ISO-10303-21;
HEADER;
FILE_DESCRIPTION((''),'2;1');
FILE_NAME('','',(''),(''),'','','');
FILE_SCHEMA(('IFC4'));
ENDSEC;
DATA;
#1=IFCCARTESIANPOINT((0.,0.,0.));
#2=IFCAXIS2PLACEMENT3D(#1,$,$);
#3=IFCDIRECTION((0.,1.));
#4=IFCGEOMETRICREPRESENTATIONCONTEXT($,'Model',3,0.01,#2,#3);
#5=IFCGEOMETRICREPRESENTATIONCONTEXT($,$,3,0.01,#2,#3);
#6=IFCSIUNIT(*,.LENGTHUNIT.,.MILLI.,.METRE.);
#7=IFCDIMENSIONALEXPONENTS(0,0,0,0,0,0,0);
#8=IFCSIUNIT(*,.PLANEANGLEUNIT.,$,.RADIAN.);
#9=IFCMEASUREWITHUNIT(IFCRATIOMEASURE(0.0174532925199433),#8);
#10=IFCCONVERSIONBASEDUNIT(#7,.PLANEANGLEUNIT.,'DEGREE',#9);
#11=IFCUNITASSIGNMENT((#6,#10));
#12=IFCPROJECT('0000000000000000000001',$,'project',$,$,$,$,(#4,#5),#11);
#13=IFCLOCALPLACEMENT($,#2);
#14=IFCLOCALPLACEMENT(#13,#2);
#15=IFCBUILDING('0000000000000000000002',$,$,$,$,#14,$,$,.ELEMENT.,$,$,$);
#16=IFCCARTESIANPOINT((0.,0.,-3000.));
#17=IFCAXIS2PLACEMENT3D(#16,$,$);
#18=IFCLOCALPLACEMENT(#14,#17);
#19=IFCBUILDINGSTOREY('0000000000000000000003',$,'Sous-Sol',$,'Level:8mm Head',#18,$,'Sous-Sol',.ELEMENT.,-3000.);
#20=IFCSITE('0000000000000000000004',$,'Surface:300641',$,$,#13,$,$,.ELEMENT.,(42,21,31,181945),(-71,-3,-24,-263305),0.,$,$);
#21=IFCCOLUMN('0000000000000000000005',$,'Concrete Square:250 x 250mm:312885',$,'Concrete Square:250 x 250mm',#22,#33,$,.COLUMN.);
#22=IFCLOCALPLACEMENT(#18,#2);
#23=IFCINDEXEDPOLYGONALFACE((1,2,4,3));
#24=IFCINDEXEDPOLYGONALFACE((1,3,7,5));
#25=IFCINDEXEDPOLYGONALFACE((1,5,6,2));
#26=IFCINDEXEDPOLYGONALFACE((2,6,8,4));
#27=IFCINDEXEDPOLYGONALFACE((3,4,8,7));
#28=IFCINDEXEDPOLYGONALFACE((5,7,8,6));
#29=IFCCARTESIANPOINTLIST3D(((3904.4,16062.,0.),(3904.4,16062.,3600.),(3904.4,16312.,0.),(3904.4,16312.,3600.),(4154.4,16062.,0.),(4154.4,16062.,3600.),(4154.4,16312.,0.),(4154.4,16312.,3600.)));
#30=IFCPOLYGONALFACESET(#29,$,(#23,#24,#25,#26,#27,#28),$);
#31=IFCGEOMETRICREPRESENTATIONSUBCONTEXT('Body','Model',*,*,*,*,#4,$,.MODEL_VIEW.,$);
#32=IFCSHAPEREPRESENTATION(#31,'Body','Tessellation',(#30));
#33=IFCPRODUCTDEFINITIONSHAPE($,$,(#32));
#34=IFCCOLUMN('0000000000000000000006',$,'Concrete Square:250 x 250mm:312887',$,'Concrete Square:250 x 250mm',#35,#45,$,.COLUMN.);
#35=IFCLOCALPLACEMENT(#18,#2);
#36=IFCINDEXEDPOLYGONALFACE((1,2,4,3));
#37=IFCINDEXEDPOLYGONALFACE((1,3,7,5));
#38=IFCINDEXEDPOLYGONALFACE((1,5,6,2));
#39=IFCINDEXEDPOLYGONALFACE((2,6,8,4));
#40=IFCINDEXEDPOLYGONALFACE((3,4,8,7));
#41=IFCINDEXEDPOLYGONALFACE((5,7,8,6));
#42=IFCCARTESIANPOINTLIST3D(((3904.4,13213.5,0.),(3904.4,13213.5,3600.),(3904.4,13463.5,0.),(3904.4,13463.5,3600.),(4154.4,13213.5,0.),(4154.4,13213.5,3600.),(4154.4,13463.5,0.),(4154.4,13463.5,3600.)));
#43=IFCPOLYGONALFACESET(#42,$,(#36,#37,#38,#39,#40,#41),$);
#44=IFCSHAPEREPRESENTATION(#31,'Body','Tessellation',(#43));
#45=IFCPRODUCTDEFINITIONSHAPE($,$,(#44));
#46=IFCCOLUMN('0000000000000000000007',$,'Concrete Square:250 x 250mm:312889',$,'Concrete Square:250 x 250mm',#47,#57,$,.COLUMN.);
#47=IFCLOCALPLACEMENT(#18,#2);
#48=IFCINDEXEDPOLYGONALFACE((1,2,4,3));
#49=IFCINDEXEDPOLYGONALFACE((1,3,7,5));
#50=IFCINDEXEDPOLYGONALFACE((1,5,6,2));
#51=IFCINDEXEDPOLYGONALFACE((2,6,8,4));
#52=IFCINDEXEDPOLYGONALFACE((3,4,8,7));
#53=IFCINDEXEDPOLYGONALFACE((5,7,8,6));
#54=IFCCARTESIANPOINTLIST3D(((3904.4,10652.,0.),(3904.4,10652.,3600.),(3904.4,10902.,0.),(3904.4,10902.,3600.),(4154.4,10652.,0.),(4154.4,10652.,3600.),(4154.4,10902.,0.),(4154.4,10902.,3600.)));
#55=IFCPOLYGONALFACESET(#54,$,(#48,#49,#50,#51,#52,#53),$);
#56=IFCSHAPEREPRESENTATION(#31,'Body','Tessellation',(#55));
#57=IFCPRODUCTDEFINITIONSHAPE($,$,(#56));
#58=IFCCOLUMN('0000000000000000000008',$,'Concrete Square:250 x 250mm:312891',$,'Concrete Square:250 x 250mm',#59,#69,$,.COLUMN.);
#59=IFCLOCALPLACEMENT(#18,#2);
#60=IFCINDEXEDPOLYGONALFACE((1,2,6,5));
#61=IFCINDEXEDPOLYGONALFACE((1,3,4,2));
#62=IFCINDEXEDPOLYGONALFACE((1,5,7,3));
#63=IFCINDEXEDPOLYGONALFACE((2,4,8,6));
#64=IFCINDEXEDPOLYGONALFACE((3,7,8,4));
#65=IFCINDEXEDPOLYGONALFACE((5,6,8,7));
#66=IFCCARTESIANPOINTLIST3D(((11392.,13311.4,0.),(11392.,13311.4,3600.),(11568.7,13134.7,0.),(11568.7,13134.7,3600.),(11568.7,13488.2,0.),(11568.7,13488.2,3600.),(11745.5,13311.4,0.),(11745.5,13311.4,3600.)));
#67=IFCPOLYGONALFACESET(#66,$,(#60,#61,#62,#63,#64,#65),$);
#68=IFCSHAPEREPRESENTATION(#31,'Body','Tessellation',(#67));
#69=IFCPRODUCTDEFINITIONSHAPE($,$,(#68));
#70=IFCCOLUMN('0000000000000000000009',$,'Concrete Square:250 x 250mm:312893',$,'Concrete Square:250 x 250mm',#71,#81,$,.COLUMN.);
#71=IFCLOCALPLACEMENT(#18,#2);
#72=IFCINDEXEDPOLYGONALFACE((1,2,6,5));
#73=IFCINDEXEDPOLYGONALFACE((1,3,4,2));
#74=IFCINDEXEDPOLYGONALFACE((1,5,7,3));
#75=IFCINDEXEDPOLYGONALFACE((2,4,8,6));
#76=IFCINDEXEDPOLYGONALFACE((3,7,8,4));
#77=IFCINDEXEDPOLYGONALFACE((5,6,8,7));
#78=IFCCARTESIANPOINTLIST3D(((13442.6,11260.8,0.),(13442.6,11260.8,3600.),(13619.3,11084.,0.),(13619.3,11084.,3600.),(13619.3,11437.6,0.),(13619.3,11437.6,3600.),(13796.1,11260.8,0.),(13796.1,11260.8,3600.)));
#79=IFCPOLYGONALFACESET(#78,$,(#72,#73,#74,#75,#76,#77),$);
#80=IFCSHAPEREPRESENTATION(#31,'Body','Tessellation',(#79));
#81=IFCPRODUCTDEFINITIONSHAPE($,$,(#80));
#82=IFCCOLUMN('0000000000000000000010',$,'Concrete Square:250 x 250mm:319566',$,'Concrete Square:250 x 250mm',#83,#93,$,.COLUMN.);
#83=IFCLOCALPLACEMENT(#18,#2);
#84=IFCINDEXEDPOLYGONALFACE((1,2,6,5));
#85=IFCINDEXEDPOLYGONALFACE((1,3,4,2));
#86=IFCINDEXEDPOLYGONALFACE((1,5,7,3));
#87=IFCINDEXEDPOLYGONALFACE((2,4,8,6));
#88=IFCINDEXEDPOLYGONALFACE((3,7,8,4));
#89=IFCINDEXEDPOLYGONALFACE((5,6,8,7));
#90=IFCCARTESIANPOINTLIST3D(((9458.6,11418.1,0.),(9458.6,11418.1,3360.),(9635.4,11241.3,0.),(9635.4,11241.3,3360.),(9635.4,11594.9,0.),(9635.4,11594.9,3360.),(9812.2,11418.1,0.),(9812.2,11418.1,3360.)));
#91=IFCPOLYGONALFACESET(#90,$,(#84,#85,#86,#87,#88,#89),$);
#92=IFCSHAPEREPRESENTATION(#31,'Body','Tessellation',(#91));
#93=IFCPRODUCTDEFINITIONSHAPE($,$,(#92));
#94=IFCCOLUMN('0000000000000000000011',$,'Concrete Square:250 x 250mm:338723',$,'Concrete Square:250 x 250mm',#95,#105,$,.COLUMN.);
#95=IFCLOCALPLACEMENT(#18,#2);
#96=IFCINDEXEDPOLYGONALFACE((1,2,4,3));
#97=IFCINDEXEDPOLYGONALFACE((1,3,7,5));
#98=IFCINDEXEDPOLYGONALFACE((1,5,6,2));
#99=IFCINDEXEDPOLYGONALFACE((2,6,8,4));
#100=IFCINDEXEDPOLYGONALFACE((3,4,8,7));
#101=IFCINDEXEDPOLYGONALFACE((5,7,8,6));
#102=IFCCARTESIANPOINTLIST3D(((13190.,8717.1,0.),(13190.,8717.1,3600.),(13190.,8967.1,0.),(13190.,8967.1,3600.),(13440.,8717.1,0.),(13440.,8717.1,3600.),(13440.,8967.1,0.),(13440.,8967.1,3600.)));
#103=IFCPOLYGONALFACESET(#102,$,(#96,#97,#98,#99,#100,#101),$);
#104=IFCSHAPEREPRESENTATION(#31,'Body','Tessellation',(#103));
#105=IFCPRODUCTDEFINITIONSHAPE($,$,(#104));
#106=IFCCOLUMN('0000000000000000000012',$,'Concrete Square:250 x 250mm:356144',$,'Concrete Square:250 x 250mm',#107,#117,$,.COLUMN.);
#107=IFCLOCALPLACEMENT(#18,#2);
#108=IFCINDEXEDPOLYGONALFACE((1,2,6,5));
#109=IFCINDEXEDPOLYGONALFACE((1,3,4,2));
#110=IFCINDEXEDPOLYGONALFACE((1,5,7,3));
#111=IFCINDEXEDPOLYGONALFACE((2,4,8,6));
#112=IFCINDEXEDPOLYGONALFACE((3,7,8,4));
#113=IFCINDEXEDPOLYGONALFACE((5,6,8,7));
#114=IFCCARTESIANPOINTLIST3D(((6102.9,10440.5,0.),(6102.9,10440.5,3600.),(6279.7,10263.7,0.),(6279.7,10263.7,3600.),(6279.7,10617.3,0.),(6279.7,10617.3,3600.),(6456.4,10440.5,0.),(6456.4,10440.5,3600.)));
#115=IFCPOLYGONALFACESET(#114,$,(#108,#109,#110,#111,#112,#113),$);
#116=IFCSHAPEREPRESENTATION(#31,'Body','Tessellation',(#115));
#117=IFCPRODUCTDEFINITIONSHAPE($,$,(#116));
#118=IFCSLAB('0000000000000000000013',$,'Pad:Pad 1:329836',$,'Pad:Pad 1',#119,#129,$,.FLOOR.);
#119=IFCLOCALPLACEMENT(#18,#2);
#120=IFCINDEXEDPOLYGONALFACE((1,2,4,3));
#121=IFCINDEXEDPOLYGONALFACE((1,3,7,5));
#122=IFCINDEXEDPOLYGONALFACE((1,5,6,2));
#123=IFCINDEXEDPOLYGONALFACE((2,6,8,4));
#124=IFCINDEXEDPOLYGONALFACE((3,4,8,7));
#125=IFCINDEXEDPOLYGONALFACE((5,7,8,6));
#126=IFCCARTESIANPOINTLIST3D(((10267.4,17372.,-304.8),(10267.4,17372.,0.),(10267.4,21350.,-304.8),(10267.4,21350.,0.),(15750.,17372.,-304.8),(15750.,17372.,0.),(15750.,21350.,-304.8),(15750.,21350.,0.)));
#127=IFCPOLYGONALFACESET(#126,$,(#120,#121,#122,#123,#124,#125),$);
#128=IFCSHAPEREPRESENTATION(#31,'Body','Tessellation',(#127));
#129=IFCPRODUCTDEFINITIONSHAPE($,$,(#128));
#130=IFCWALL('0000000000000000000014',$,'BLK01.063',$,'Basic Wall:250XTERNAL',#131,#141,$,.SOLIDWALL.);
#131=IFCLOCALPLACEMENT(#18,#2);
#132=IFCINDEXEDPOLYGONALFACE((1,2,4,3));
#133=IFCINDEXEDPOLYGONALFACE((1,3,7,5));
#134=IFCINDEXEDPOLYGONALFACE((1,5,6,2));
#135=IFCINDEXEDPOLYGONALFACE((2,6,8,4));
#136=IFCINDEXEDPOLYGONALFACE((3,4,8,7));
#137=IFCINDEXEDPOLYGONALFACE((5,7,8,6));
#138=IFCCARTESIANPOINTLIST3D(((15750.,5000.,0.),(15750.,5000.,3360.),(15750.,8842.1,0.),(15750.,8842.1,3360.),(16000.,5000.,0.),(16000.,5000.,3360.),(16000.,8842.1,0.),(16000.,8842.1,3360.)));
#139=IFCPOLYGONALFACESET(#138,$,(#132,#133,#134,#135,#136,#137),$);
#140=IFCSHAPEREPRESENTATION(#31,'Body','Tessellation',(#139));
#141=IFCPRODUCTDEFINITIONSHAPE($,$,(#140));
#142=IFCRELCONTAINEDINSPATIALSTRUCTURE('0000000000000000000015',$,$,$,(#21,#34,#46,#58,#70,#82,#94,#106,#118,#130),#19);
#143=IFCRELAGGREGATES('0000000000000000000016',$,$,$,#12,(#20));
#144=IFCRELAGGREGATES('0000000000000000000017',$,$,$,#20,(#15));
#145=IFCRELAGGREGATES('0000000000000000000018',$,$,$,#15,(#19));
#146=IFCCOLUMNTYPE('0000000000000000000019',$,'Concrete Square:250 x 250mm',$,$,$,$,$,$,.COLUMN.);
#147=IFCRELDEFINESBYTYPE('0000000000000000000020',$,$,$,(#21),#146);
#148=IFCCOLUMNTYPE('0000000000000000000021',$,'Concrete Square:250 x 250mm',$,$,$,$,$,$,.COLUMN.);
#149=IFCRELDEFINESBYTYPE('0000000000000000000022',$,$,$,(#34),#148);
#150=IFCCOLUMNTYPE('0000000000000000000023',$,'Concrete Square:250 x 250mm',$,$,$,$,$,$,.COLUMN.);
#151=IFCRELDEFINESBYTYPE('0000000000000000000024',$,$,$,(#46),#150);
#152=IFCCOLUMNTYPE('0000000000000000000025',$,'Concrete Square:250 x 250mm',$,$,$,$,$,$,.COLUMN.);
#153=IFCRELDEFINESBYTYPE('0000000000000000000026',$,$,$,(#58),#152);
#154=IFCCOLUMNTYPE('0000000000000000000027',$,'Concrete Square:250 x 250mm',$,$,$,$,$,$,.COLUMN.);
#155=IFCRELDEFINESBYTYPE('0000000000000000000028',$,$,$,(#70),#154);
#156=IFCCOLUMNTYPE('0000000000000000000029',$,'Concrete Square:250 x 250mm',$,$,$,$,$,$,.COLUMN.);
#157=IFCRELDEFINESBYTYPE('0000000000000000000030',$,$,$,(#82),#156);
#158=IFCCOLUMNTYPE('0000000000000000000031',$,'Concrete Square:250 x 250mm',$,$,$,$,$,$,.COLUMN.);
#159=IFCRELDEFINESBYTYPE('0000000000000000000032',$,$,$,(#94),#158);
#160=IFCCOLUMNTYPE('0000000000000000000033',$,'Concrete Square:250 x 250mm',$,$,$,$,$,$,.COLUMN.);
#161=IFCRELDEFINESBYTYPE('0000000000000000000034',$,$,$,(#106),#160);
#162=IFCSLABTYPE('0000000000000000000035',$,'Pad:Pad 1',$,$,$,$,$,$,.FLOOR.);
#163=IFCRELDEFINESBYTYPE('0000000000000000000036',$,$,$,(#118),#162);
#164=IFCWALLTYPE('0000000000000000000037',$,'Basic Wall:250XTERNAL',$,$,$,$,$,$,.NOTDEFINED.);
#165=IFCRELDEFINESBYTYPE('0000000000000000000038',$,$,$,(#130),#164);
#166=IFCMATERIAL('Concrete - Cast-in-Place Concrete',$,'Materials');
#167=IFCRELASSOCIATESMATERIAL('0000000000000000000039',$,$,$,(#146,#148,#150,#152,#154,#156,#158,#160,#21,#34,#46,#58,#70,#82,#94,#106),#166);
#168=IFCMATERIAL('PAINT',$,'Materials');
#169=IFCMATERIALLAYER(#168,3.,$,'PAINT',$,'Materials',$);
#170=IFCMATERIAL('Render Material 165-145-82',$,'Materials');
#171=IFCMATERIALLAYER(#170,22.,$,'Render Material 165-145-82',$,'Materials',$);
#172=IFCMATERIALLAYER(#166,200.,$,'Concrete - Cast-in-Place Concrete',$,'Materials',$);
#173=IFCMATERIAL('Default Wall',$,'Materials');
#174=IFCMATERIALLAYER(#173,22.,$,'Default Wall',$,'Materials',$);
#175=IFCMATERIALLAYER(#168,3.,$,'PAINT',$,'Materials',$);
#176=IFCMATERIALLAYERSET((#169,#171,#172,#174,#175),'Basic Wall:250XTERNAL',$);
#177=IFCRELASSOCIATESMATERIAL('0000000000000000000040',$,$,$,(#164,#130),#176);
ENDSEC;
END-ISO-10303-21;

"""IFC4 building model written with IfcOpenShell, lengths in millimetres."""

from ifc_helpers import new_model, entity, si_unit, converted_unit, direction, frame, frame_2d, origin, origin_2d_with_axis, place, context, subcontext, project, spatial, polyline, rectangle, extrude, clip, halfspace, bounded_halfspace, source, transform, mapped, material, layer, layer_set, layer_usage, material_profile, profile_set, profile_usage, type_object, type_shapes, element, save


model = new_model("IFC4")

# Units and contexts
model_context = context("Model", 3, precision=0.01, world=origin(), true_north=direction((0.0, 1.0)))
context_of_model = context(None, 3, precision=0.01, world=origin(), true_north=direction((0.0, 1.0)))
body_context = subcontext(model_context, "Body", "Model", "MODEL_VIEW")
ifc_project = project(units=[si_unit("LENGTHUNIT", "METRE", prefix="MILLI"), converted_unit("PLANEANGLEUNIT", "DEGREE", entity("IfcRatioMeasure", 0.0174532925199433), si_unit("PLANEANGLEUNIT", "RADIAN"), dimensions=[0, 0, 0, 0, 0, 0, 0])], contexts=[model_context, context_of_model])

# Site, building, storey
site_placement = place(None, origin())
site = spatial("IfcSite", under=ifc_project, at=site_placement, Name="Surface:300641", CompositionType="ELEMENT", RefLatitude=(42, 21, 31, 181945), RefLongitude=(-71, -3, -24, -263305), RefElevation=0.0)
building_placement = place(site_placement, origin())
building = spatial("IfcBuilding", under=site, at=building_placement, CompositionType="ELEMENT")
storey_placement = place(building_placement, frame((0.0, 0.0, -3000.0)))
storey = spatial("IfcBuildingStorey", under=building, at=storey_placement, Name="Sous-Sol", ObjectType="Level:8mm Head", LongName="Sous-Sol", CompositionType="ELEMENT", Elevation=-3000.0)

# Columns
ifc_material_1 = material(Name="Concrete - Cast-in-Place Concrete", Category="Materials")
ifc_material_profile = material_profile(ifc_material_1, rectangle(XDim=250.0, YDim=250.0, at=frame_2d((0.0, 0.0), x_axis=(1.0, 0.0))), Name="250 x 250mm")
ifc_profile_set = profile_set([ifc_material_profile], Name="250 x 250mm")
ifc_profile_usage_1 = profile_usage(ifc_profile_set)
column_type_1 = type_object("IfcColumnType", Name="Concrete Square:250 x 250mm", PredefinedType="COLUMN", material=ifc_profile_set)
shared_shape_1 = source(origin(), body_context, "Body", "SweptSolid", [
    extrude(rectangle(XDim=250.0, YDim=250.0, at=frame_2d((0.0, 0.0), x_axis=(1.0, 0.0))), frame((4029.4, 16187.0, -3000.0), z_axis=(0.0, 0.0, 1.0), x_axis=(0.0, -1.0, 0.0)), (0.0, 0.0, 1.0), 3600.0),
])
type_shapes(column_type_1, [shared_shape_1])
column_1_placement = place(storey_placement, frame((0.0, 0.0, 3000.0)))
element("IfcColumn", 1, at=column_1_placement, inside=storey, type_object=column_type_1, material=ifc_profile_usage_1, Name="Concrete Square:250 x 250mm:312885", ObjectType="Concrete Square:250 x 250mm", PredefinedType="COLUMN", context=body_context, shape_type="MappedRepresentation", body=[
    mapped(shared_shape_1, transform((0.0, 0.0, 0.0), scale=1.0)),
])
ifc_profile_usage_2 = profile_usage(ifc_profile_set)
column_type_2 = type_object("IfcColumnType", Name="Concrete Square:250 x 250mm", PredefinedType="COLUMN", material=ifc_profile_set)
shared_shape_2 = source(origin(), body_context, "Body", "SweptSolid", [
    extrude(rectangle(XDim=250.0, YDim=250.0, at=frame_2d((0.0, 0.0), x_axis=(1.0, 0.0))), frame((4029.4, 13338.5, -3000.0), z_axis=(0.0, 0.0, 1.0), x_axis=(0.0, -1.0, 0.0)), (0.0, 0.0, 1.0), 3600.0),
])
type_shapes(column_type_2, [shared_shape_2])
column_2_placement = place(storey_placement, frame((0.0, 0.0, 3000.0)))
element("IfcColumn", 2, at=column_2_placement, inside=storey, type_object=column_type_2, material=ifc_profile_usage_2, Name="Concrete Square:250 x 250mm:312887", ObjectType="Concrete Square:250 x 250mm", PredefinedType="COLUMN", context=body_context, shape_type="MappedRepresentation", body=[
    mapped(shared_shape_2, transform((0.0, 0.0, 0.0), scale=1.0)),
])
ifc_profile_usage_3 = profile_usage(ifc_profile_set)
column_type_3 = type_object("IfcColumnType", Name="Concrete Square:250 x 250mm", PredefinedType="COLUMN", material=ifc_profile_set)
shared_shape_3 = source(origin(), body_context, "Body", "SweptSolid", [
    extrude(rectangle(XDim=250.0, YDim=250.0, at=frame_2d((0.0, 0.0), x_axis=(1.0, 0.0))), frame((4029.4, 10777.0, -3000.0), z_axis=(0.0, 0.0, 1.0), x_axis=(0.0, -1.0, 0.0)), (0.0, 0.0, 1.0), 3600.0),
])
type_shapes(column_type_3, [shared_shape_3])
column_3_placement = place(storey_placement, frame((0.0, 0.0, 3000.0)))
element("IfcColumn", 3, at=column_3_placement, inside=storey, type_object=column_type_3, material=ifc_profile_usage_3, Name="Concrete Square:250 x 250mm:312889", ObjectType="Concrete Square:250 x 250mm", PredefinedType="COLUMN", context=body_context, shape_type="MappedRepresentation", body=[
    mapped(shared_shape_3, transform((0.0, 0.0, 0.0), scale=1.0)),
])
ifc_profile_usage_4 = profile_usage(ifc_profile_set)
column_type_4 = type_object("IfcColumnType", Name="Concrete Square:250 x 250mm", PredefinedType="COLUMN", material=ifc_profile_set)
shared_shape_4 = source(origin(), body_context, "Body", "SweptSolid", [
    extrude(rectangle(XDim=250.0, YDim=250.0, at=origin_2d_with_axis()), frame((11568.7, 13311.4, -3000.0), z_axis=(0.0, 0.0, 1.0), x_axis=(-0.707107, 0.707107, 0.0)), (0.0, 0.0, 1.0), 3600.0),
])
type_shapes(column_type_4, [shared_shape_4])
column_4_placement = place(storey_placement, frame((0.0, 0.0, 3000.0)))
element("IfcColumn", 4, at=column_4_placement, inside=storey, type_object=column_type_4, material=ifc_profile_usage_4, Name="Concrete Square:250 x 250mm:312891", ObjectType="Concrete Square:250 x 250mm", PredefinedType="COLUMN", context=body_context, shape_type="MappedRepresentation", body=[
    mapped(shared_shape_4, transform((0.0, 0.0, 0.0), scale=1.0)),
])
ifc_profile_usage_5 = profile_usage(ifc_profile_set)
column_type_5 = type_object("IfcColumnType", Name="Concrete Square:250 x 250mm", PredefinedType="COLUMN", material=ifc_profile_set)
shared_shape_5 = source(origin(), body_context, "Body", "SweptSolid", [
    extrude(rectangle(XDim=250.0, YDim=250.0, at=frame_2d((0.0, 0.0), x_axis=(1.0, 0.0))), frame((13619.3, 11260.8, -3000.0), z_axis=(0.0, 0.0, 1.0), x_axis=(-0.707107, 0.707107, 0.0)), (0.0, 0.0, 1.0), 3600.0),
])
type_shapes(column_type_5, [shared_shape_5])
column_5_placement = place(storey_placement, frame((0.0, 0.0, 3000.0)))
element("IfcColumn", 5, at=column_5_placement, inside=storey, type_object=column_type_5, material=ifc_profile_usage_5, Name="Concrete Square:250 x 250mm:312893", ObjectType="Concrete Square:250 x 250mm", PredefinedType="COLUMN", context=body_context, shape_type="MappedRepresentation", body=[
    mapped(shared_shape_5, transform((0.0, 0.0, 0.0), scale=1.0)),
])
ifc_profile_usage_6 = profile_usage(ifc_profile_set)
column_type_6 = type_object("IfcColumnType", Name="Concrete Square:250 x 250mm", PredefinedType="COLUMN", material=ifc_profile_set)
shared_shape_6 = source(origin(), body_context, "Body", "SweptSolid", [
    extrude(rectangle(XDim=250.0, YDim=250.0, at=frame_2d((0.0, 0.0), x_axis=(1.0, 0.0))), frame((9635.4, 11418.1, -3000.0), z_axis=(0.0, 0.0, 1.0), x_axis=(-0.707107, 0.707107, 0.0)), (0.0, 0.0, 1.0), 3360.0),
])
type_shapes(column_type_6, [shared_shape_6])
column_6_placement = place(storey_placement, frame((0.0, 0.0, 3000.0)))
element("IfcColumn", 6, at=column_6_placement, inside=storey, type_object=column_type_6, material=ifc_profile_usage_6, Name="Concrete Square:250 x 250mm:319566", ObjectType="Concrete Square:250 x 250mm", PredefinedType="COLUMN", context=body_context, shape_type="MappedRepresentation", body=[
    mapped(shared_shape_6, transform((0.0, 0.0, 0.0), scale=1.0)),
])
ifc_profile_usage_7 = profile_usage(ifc_profile_set)
column_type_7 = type_object("IfcColumnType", Name="Concrete Square:250 x 250mm", PredefinedType="COLUMN", material=ifc_profile_set)
shared_shape_7 = source(origin(), body_context, "Body", "SweptSolid", [
    extrude(rectangle(XDim=250.0, YDim=250.0, at=frame_2d((0.0, 0.0), x_axis=(1.0, 0.0))), frame((13315.0, 8842.1, -3000.0), z_axis=(0.0, 0.0, 1.0), x_axis=(0.0, -1.0, 0.0)), (0.0, 0.0, 1.0), 3600.0),
])
type_shapes(column_type_7, [shared_shape_7])
column_7_placement = place(storey_placement, frame((0.0, 0.0, 3000.0)))
element("IfcColumn", 7, at=column_7_placement, inside=storey, type_object=column_type_7, material=ifc_profile_usage_7, Name="Concrete Square:250 x 250mm:338723", ObjectType="Concrete Square:250 x 250mm", PredefinedType="COLUMN", context=body_context, shape_type="MappedRepresentation", body=[
    mapped(shared_shape_7, transform((0.0, 0.0, 0.0), scale=1.0)),
])
ifc_profile_usage_8 = profile_usage(ifc_profile_set)
column_type_8 = type_object("IfcColumnType", Name="Concrete Square:250 x 250mm", PredefinedType="COLUMN", material=ifc_profile_set)
shared_shape_8 = source(origin(), body_context, "Body", "SweptSolid", [
    extrude(rectangle(XDim=250.0, YDim=250.0, at=origin_2d_with_axis()), frame((6279.7, 10440.5, -3000.0), z_axis=(0.0, 0.0, 1.0), x_axis=(-0.707107, 0.707107, 0.0)), (0.0, 0.0, 1.0), 3600.0),
])
type_shapes(column_type_8, [shared_shape_8])
column_8_placement = place(storey_placement, frame((0.0, 0.0, 3000.0)))
element("IfcColumn", 8, at=column_8_placement, inside=storey, type_object=column_type_8, material=ifc_profile_usage_8, Name="Concrete Square:250 x 250mm:356144", ObjectType="Concrete Square:250 x 250mm", PredefinedType="COLUMN", context=body_context, shape_type="MappedRepresentation", body=[
    mapped(shared_shape_8, transform((0.0, 0.0, 0.0), scale=1.0)),
])

# Slab
slab_type_1 = type_object("IfcSlabType", Name="Pad:Pad 1", PredefinedType="FLOOR")
slab_1_placement = place(storey_placement, origin())
element("IfcSlab", 9, at=slab_1_placement, inside=storey, type_object=slab_type_1, Name="Pad:Pad 1:329836", ObjectType="Pad:Pad 1", PredefinedType="FLOOR", context=body_context, shape_type="SweptSolid", body=[
    extrude(rectangle(XDim=5482.6, YDim=3978.0, at=frame_2d((0.0, 0.0), x_axis=(1.0, 0.0))), frame((13008.7, 19361.0, -304.8)), (0.0, 0.0, 1.0), 304.8),
])

# Wall
ifc_material_2 = material(Name="PAINT", Category="Materials")
ifc_layer_1 = layer(ifc_material_2, 3.0, Name="PAINT", Category="Materials")
ifc_material_3 = material(Name="Render Material 165-145-82", Category="Materials")
ifc_layer_2 = layer(ifc_material_3, 22.0, Name="Render Material 165-145-82", Category="Materials")
ifc_layer_3 = layer(ifc_material_1, 200.0, Name="Concrete - Cast-in-Place Concrete", Category="Materials")
ifc_material_4 = material(Name="Default Wall", Category="Materials")
ifc_layer_4 = layer(ifc_material_4, 22.0, Name="Default Wall", Category="Materials")
ifc_layer_5 = layer(ifc_material_2, 3.0, Name="PAINT", Category="Materials")
ifc_layer_set = layer_set([ifc_layer_1, ifc_layer_2, ifc_layer_3, ifc_layer_4, ifc_layer_5], Name="Basic Wall:250XTERNAL")
ifc_layer_usage_1 = layer_usage(ifc_layer_set, "AXIS2", "NEGATIVE", 125.0)
wall_type = type_object("IfcWallType", Name="Basic Wall:250XTERNAL", PredefinedType="NOTDEFINED", material=ifc_layer_set)
wall_1_placement = place(storey_placement, frame((15875.0, 5000.0, 0.0), z_axis=(0.0, 0.0, 1.0), x_axis=(0.0, 1.0, 0.0)))
element("IfcWall", 10, at=wall_1_placement, inside=storey, type_object=wall_type, material=ifc_layer_usage_1, Name="BLK01.063", ObjectType="Basic Wall:250XTERNAL", PredefinedType="SOLIDWALL", context=body_context, shape_type="Clipping", body=[
    clip(clip(extrude(rectangle(XDim=3842.1, YDim=250.0, at=frame_2d((1921.1, 0.0), x_axis=(-1.0, 0.0))), origin(), (0.0, 0.0, 1.0), 3360.0), bounded_halfspace(frame((0.0, 125.0, 3360.0), z_axis=(0.0, 0.0, -1.0), x_axis=(-1.0, 0.0, 0.0)), True, frame((0.0, 125.0, 3360.0)), polyline([(0.0, 0.0), (0.0, -250.0), (125.0, -250.0), (3842.1, -250.0), (3842.1, 0.0), (150.0, 0.0), (125.0, 0.0), (0.0, 0.0)]))), halfspace(origin(), True)),
])

save(model, "model.ifc")
